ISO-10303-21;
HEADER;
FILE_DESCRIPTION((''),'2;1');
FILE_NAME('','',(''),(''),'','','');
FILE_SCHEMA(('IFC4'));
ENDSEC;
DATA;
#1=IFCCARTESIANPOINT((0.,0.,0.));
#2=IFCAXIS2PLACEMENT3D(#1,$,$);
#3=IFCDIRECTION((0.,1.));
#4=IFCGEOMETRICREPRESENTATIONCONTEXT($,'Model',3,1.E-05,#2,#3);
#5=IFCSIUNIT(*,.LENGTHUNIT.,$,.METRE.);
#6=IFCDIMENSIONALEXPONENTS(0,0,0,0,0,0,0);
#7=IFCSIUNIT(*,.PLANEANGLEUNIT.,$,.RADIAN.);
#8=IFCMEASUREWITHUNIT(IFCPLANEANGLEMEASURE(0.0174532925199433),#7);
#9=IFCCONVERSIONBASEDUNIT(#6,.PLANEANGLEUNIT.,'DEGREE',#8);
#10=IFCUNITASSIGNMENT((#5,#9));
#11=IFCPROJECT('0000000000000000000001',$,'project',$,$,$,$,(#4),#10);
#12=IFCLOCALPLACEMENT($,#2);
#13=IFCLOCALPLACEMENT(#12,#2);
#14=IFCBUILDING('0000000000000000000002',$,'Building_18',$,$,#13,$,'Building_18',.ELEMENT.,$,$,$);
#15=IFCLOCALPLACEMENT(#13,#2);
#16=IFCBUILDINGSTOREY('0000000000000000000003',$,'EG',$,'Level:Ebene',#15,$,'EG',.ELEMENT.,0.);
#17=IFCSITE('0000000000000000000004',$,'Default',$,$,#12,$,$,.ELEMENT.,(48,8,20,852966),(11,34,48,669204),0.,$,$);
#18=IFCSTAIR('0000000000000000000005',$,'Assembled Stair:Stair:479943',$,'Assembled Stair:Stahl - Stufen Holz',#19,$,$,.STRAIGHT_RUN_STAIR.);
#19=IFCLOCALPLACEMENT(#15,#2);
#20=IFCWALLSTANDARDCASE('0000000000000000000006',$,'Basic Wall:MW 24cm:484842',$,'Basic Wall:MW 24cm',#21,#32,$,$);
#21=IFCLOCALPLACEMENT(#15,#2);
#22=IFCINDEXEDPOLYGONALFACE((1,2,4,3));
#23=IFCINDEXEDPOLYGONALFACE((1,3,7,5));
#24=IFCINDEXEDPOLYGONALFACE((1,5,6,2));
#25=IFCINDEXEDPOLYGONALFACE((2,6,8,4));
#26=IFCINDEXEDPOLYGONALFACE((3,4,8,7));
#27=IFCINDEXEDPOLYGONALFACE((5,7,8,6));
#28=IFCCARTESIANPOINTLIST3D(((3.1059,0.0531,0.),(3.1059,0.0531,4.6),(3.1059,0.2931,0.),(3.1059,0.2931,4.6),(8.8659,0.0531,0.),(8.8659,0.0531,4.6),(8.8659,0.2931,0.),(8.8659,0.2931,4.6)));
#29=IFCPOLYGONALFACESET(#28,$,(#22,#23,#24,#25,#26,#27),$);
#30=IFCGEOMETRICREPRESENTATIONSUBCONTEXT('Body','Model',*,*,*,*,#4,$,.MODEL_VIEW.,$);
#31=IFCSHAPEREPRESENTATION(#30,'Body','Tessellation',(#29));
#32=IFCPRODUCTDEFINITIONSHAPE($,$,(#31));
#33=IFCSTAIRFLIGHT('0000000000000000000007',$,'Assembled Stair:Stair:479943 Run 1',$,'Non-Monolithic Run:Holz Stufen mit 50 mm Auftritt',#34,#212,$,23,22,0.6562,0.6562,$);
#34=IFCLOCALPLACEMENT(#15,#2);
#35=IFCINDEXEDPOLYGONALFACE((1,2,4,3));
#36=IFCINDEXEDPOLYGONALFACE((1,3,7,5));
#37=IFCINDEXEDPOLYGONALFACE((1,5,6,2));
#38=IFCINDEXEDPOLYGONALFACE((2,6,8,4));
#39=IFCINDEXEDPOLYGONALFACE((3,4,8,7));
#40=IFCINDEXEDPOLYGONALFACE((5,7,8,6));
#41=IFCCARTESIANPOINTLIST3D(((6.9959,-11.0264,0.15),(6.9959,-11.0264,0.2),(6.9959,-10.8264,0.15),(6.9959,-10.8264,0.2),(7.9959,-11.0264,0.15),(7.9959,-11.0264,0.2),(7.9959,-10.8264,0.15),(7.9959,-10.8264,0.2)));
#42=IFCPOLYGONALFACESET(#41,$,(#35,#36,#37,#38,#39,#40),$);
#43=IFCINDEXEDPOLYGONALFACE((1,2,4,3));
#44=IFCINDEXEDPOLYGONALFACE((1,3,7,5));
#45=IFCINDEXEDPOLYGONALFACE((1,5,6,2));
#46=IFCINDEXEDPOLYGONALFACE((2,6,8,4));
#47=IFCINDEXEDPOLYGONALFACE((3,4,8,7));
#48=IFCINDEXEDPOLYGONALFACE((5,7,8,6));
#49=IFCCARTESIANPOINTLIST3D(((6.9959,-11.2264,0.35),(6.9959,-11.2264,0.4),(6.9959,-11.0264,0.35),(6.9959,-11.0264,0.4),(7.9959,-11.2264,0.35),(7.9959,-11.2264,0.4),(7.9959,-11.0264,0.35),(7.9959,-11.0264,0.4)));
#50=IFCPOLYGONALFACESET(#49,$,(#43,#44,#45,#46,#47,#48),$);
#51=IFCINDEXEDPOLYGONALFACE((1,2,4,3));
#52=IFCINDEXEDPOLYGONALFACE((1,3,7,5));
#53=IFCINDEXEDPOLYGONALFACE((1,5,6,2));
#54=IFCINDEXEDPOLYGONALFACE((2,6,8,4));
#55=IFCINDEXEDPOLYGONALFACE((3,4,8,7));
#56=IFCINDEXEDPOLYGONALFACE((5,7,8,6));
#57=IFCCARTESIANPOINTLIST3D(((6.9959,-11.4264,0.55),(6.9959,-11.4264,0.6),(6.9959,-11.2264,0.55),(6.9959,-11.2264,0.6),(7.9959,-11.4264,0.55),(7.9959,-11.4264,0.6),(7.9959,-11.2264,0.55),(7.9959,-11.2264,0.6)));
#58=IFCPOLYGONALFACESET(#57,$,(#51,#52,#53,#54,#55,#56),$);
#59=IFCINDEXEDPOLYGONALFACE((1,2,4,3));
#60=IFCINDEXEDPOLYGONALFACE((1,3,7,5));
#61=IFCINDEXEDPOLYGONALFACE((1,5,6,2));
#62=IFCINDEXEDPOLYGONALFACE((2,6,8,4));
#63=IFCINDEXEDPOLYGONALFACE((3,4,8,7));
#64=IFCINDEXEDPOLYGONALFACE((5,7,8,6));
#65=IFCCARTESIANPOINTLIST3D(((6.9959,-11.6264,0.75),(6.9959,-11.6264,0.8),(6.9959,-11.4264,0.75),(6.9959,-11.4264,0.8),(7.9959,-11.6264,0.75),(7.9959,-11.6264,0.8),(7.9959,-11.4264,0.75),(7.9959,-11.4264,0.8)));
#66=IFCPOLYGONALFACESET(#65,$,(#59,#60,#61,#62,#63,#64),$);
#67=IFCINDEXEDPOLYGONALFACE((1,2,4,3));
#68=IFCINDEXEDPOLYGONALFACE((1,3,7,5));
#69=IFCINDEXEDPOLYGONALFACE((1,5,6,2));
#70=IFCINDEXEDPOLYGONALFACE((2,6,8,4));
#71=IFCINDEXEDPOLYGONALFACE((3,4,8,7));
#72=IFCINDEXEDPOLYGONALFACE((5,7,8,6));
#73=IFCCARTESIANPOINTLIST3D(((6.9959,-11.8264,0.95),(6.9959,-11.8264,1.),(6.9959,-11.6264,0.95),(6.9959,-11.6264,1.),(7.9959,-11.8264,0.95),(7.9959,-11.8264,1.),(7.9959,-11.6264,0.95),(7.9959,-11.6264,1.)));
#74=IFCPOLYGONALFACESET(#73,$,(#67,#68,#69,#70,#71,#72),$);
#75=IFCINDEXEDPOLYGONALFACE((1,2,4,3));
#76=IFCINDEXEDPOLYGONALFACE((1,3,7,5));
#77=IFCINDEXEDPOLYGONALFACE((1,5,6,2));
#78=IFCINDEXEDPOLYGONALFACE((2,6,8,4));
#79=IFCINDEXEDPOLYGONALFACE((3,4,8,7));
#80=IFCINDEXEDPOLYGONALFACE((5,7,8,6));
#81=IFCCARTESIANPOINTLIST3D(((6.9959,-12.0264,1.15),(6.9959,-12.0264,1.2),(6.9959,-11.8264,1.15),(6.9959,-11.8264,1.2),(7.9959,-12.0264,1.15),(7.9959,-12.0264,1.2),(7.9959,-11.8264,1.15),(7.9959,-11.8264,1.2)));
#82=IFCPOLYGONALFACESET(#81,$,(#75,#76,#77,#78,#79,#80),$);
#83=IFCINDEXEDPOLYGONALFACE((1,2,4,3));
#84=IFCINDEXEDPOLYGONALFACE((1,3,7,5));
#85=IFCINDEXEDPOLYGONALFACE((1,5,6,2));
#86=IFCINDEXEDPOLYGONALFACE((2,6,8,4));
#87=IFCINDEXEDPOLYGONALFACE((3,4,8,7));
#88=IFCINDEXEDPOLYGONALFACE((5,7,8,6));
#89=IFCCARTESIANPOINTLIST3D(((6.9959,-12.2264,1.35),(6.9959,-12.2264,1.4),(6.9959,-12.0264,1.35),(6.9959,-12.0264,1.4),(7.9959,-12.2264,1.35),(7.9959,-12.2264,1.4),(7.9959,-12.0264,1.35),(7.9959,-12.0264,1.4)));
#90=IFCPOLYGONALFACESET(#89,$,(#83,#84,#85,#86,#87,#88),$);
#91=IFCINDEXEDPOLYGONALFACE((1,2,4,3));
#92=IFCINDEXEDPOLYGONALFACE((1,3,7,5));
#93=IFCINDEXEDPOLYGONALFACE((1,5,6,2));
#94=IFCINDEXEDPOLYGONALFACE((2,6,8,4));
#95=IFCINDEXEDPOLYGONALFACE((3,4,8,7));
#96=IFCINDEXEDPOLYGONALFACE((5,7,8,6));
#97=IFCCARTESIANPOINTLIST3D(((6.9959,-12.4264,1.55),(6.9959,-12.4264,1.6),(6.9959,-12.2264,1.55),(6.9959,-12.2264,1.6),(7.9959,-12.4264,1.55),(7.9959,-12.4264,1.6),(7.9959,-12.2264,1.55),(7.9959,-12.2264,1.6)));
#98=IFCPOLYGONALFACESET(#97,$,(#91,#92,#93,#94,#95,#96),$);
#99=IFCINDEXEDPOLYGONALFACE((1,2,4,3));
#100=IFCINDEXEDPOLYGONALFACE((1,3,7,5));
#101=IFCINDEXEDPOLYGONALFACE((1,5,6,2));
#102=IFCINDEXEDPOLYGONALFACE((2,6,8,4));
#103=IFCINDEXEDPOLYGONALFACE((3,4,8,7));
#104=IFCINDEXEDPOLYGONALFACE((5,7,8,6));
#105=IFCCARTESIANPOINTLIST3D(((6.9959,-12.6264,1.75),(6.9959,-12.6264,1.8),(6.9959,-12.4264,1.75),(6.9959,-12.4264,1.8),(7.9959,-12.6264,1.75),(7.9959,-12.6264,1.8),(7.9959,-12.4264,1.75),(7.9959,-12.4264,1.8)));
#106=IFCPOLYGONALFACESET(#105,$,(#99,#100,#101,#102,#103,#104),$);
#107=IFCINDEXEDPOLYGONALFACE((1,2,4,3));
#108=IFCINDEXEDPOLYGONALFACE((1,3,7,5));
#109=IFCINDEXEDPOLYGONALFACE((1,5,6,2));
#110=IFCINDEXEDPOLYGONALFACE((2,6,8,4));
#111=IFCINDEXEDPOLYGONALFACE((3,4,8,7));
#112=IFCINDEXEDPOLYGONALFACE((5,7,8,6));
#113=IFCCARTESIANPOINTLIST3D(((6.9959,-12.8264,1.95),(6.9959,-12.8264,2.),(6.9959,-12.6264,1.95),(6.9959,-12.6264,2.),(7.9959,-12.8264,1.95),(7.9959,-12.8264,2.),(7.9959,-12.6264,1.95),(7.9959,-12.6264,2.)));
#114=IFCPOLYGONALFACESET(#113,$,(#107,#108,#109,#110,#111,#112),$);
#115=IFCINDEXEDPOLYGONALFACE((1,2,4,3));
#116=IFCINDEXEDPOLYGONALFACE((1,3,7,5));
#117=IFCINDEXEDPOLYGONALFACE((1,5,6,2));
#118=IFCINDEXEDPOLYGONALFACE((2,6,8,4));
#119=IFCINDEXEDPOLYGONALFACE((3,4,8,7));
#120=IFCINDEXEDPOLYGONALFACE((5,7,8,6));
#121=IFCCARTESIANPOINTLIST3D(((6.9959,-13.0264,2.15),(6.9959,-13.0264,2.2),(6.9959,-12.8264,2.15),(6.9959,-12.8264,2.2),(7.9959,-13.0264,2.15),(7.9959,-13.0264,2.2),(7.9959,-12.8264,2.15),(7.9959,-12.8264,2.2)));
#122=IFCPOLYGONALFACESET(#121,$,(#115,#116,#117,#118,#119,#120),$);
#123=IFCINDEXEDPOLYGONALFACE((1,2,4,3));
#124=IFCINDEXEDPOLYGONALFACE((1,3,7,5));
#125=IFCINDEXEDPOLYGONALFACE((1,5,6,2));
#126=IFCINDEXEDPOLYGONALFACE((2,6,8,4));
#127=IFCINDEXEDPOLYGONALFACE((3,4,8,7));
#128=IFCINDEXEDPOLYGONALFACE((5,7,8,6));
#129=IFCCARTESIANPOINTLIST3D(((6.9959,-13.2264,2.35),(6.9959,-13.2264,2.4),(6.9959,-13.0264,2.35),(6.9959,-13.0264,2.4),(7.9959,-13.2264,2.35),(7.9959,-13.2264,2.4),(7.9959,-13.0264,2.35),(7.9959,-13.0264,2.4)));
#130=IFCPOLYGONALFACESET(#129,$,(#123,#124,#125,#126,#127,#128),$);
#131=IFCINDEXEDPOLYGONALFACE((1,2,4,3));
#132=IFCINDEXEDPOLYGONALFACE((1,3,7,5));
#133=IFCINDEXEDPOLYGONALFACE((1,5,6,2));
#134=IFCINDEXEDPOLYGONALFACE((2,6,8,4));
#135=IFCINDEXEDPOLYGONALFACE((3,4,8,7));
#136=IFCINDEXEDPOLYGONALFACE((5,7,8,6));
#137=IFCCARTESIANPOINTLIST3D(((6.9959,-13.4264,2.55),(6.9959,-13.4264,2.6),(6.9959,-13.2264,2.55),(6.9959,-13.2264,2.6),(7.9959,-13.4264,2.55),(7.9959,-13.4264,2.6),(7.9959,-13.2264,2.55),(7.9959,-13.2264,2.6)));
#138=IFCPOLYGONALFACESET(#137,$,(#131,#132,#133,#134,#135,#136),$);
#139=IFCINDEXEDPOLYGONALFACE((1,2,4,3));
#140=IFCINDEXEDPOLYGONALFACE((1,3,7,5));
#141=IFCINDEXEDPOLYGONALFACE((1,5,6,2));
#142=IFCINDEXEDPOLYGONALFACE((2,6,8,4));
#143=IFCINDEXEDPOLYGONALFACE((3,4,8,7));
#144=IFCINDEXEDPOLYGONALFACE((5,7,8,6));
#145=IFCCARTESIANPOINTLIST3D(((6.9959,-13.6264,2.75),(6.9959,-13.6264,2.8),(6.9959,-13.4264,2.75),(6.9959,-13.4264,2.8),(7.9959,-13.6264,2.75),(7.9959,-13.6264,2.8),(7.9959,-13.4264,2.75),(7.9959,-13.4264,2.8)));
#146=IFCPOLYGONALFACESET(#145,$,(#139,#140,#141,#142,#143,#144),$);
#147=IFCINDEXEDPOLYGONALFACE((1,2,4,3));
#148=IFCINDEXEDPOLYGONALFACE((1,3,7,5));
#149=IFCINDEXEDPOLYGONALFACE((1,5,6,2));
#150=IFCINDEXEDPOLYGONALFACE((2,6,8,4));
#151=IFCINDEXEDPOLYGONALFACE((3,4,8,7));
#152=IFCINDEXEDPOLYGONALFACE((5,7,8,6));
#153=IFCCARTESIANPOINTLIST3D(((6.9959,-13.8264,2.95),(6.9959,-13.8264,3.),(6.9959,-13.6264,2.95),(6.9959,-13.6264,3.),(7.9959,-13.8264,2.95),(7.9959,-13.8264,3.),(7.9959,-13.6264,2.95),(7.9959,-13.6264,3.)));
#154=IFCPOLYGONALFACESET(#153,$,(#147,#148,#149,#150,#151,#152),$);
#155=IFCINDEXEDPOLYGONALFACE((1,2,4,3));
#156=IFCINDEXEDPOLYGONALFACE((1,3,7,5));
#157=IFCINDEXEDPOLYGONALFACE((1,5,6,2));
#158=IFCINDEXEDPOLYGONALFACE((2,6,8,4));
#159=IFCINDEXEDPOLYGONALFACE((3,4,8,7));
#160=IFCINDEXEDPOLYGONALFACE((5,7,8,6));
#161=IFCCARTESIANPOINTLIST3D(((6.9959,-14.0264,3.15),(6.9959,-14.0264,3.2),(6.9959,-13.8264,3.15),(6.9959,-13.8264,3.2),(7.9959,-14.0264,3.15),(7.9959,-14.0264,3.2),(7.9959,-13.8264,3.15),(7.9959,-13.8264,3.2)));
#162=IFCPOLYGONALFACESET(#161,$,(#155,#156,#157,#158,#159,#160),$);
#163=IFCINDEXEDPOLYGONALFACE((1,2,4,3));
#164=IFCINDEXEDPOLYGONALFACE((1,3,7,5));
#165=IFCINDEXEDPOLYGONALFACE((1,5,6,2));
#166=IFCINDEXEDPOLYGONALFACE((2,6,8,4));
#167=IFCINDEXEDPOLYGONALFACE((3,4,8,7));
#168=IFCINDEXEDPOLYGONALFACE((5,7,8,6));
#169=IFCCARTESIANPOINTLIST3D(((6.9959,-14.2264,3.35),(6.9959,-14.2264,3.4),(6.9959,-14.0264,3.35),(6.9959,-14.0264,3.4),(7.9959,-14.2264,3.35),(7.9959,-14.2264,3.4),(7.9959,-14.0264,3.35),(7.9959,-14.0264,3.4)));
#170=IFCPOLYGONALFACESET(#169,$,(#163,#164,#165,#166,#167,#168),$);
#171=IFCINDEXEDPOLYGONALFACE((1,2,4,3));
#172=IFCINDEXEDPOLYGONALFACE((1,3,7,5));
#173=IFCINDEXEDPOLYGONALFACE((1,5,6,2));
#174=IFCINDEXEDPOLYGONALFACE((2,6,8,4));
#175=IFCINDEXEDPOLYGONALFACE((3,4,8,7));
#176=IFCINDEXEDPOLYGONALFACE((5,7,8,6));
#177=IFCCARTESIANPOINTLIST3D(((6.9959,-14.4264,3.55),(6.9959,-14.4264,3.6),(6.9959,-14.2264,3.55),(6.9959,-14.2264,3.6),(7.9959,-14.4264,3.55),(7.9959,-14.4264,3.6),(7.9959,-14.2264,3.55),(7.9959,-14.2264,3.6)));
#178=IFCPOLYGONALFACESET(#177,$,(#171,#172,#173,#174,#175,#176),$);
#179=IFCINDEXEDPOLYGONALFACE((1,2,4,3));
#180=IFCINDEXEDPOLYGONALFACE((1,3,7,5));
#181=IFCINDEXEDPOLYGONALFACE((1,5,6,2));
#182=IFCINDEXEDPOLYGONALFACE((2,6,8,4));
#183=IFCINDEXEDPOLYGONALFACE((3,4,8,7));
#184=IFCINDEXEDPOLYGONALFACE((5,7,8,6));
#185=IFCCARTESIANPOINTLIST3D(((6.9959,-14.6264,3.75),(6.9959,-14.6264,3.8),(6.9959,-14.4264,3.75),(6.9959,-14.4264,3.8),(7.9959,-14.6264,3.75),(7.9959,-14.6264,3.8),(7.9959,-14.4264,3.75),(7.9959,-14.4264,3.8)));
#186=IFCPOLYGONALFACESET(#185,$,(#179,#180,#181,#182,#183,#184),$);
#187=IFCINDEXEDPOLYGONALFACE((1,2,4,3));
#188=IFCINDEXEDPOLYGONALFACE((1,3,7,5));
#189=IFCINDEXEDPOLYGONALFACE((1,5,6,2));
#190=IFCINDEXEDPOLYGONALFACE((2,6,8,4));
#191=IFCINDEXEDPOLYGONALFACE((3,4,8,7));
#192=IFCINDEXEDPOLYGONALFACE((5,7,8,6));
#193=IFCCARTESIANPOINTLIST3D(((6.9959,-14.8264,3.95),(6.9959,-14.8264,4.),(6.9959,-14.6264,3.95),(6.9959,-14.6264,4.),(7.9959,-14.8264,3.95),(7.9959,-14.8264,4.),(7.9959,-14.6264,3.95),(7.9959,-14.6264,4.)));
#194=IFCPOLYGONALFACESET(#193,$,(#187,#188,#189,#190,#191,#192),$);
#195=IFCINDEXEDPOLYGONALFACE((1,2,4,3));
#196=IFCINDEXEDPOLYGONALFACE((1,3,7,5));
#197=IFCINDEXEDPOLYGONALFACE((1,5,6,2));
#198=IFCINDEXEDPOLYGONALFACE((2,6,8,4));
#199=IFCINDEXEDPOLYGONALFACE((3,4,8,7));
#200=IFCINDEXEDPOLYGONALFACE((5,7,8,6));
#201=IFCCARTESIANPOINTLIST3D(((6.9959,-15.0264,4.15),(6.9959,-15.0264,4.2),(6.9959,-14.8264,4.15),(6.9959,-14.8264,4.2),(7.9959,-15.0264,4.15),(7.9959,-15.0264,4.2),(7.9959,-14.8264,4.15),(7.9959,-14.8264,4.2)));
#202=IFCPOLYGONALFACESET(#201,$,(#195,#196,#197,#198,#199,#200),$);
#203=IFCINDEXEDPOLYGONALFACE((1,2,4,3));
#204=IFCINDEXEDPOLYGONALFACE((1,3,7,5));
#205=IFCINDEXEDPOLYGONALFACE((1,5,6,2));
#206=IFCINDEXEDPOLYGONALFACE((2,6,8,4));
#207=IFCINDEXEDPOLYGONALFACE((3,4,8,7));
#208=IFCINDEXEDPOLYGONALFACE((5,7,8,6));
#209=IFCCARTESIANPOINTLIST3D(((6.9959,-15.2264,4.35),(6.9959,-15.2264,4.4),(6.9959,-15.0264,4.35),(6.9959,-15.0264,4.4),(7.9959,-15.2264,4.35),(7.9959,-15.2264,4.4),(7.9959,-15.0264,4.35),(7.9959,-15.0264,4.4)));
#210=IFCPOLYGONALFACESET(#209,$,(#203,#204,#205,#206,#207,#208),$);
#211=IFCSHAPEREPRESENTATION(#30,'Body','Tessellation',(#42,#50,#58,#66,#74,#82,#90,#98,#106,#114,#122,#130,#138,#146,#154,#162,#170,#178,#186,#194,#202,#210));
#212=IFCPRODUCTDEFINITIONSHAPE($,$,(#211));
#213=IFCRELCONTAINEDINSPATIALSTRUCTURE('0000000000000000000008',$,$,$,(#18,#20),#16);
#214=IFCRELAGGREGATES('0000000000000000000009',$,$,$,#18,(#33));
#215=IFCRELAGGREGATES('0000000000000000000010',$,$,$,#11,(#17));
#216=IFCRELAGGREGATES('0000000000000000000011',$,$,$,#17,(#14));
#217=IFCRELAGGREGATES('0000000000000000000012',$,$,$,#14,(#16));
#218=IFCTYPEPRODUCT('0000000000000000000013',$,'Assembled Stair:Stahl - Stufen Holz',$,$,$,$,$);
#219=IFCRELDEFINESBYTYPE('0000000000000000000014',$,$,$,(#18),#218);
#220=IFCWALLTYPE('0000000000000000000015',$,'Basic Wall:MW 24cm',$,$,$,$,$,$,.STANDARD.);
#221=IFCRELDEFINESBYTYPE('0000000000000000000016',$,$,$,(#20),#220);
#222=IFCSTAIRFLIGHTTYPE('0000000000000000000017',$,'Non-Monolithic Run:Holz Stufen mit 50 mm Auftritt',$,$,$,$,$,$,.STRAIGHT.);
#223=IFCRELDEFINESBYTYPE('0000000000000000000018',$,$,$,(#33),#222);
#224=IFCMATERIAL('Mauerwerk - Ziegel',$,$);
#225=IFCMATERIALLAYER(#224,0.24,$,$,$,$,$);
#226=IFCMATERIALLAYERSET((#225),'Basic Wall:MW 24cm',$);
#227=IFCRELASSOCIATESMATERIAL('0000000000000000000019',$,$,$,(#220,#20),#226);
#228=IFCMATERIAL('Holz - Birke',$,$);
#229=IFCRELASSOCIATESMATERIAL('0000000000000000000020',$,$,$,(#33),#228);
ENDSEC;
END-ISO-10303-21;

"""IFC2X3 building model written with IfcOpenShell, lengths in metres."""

from ifc_helpers import new_model, entity, si_unit, converted_unit, direction, frame, frame_2d, origin, place, context, subcontext, project, spatial, rectangle, extrude, material, layer, layer_set, layer_usage, type_object, element, aggregate, save


model = new_model("IFC2X3")

# Units and contexts
model_context = context("Model", 3, precision=1e-05, world=origin(), true_north=direction((0.0, 1.0)))
body_context = subcontext(model_context, "Body", "Model", "MODEL_VIEW")
ifc_project = project(units=[si_unit("LENGTHUNIT", "METRE"), converted_unit("PLANEANGLEUNIT", "DEGREE", entity("IfcPlaneAngleMeasure", 0.0174532925199433), si_unit("PLANEANGLEUNIT", "RADIAN"), dimensions=[0, 0, 0, 0, 0, 0, 0])], contexts=[model_context])

# Site, building, storey
site_placement = place(None, origin())
site = spatial("IfcSite", under=ifc_project, at=site_placement, Name="Default", CompositionType="ELEMENT", RefLatitude=(48, 8, 20, 852966), RefLongitude=(11, 34, 48, 669204), RefElevation=0.0)
building_placement = place(site_placement, origin())
building = spatial("IfcBuilding", under=site, at=building_placement, Name="Building_18", LongName="Building_18", CompositionType="ELEMENT")
storey_placement = place(building_placement, origin())
storey = spatial("IfcBuildingStorey", under=building, at=storey_placement, Name="EG", ObjectType="Level:Ebene", LongName="EG", CompositionType="ELEMENT", Elevation=0.0)

# Stair
type_product = type_object("IfcTypeProduct", Name="Assembled Stair:Stahl - Stufen Holz")
stair_1_placement = place(storey_placement, origin())
stair_1 = element("IfcStair", 1, at=stair_1_placement, inside=storey, type_object=type_product, Name="Assembled Stair:Stair:479943", ObjectType="Assembled Stair:Stahl - Stufen Holz", ShapeType="STRAIGHT_RUN_STAIR")

# Shared definitions
ifc_material_1 = material(Name="Mauerwerk - Ziegel")
ifc_layer = layer(ifc_material_1, 0.24)
ifc_layer_set = layer_set([ifc_layer], Name="Basic Wall:MW 24cm")
wall_type = type_object("IfcWallType", Name="Basic Wall:MW 24cm", PredefinedType="STANDARD", material=ifc_layer_set)

# Wall
ifc_layer_usage_1 = layer_usage(ifc_layer_set, "AXIS2", "NEGATIVE", 0.12)
wall_1_placement = place(storey_placement, frame((3.1059, 0.1731, 0.0)))
element("IfcWallStandardCase", 2, at=wall_1_placement, inside=storey, type_object=wall_type, material=ifc_layer_usage_1, Name="Basic Wall:MW 24cm:484842", ObjectType="Basic Wall:MW 24cm", context=body_context, shape_type="SweptSolid", body=[
    extrude(rectangle(XDim=5.76, YDim=0.24, at=frame_2d((2.88, 0.0), x_axis=(-1.0, 0.0))), origin(), (0.0, 0.0, 1.0), 4.6),
])

# Stair flight
ifc_material_2 = material(Name="Holz - Birke")
stair_flight_type = type_object("IfcStairFlightType", Name="Non-Monolithic Run:Holz Stufen mit 50 mm Auftritt", PredefinedType="STRAIGHT")
stair_flight_1_placement = place(stair_1_placement, origin())
stair_flight_1 = element("IfcStairFlight", 3, at=stair_flight_1_placement, type_object=stair_flight_type, material=ifc_material_2, Name="Assembled Stair:Stair:479943 Run 1", ObjectType="Non-Monolithic Run:Holz Stufen mit 50 mm Auftritt", NumberOfRiser=23, NumberOfTreads=22, RiserHeight=0.6562, TreadLength=0.6562, context=body_context, shape_type="SweptSolid", body=[
    extrude(rectangle(XDim=0.2, YDim=1.0, at=frame_2d((0.0, 0.0), x_axis=(1.0, 0.0))), frame((7.4959, -10.9264, 0.15), z_axis=(0.0, 0.0, 1.0), x_axis=(0.0, 1.0, 0.0)), (0.0, 0.0, 1.0), 0.05),
    extrude(rectangle(XDim=0.2, YDim=1.0, at=frame_2d((0.0, 0.0), x_axis=(1.0, 0.0))), frame((7.4959, -11.1264, 0.35), z_axis=(0.0, 0.0, 1.0), x_axis=(0.0, 1.0, 0.0)), (0.0, 0.0, 1.0), 0.05),
    extrude(rectangle(XDim=0.2, YDim=1.0, at=frame_2d((0.0, 0.0), x_axis=(1.0, 0.0))), frame((7.4959, -11.3264, 0.55), z_axis=(0.0, 0.0, 1.0), x_axis=(0.0, 1.0, 0.0)), (0.0, 0.0, 1.0), 0.05),
    extrude(rectangle(XDim=0.2, YDim=1.0, at=frame_2d((0.0, 0.0), x_axis=(1.0, 0.0))), frame((7.4959, -11.5264, 0.75), z_axis=(0.0, 0.0, 1.0), x_axis=(0.0, 1.0, 0.0)), (0.0, 0.0, 1.0), 0.05),
    extrude(rectangle(XDim=0.2, YDim=1.0, at=frame_2d((0.0, 0.0), x_axis=(1.0, 0.0))), frame((7.4959, -11.7264, 0.95), z_axis=(0.0, 0.0, 1.0), x_axis=(0.0, 1.0, 0.0)), (0.0, 0.0, 1.0), 0.05),
    extrude(rectangle(XDim=0.2, YDim=1.0, at=frame_2d((0.0, 0.0), x_axis=(1.0, 0.0))), frame((7.4959, -11.9264, 1.15), z_axis=(0.0, 0.0, 1.0), x_axis=(0.0, 1.0, 0.0)), (0.0, 0.0, 1.0), 0.05),
    extrude(rectangle(XDim=0.2, YDim=1.0, at=frame_2d((0.0, 0.0), x_axis=(1.0, 0.0))), frame((7.4959, -12.1264, 1.35), z_axis=(0.0, 0.0, 1.0), x_axis=(0.0, 1.0, 0.0)), (0.0, 0.0, 1.0), 0.05),
    extrude(rectangle(XDim=0.2, YDim=1.0, at=frame_2d((0.0, 0.0), x_axis=(1.0, 0.0))), frame((7.4959, -12.3264, 1.55), z_axis=(0.0, 0.0, 1.0), x_axis=(0.0, 1.0, 0.0)), (0.0, 0.0, 1.0), 0.05),
    extrude(rectangle(XDim=0.2, YDim=1.0, at=frame_2d((0.0, 0.0), x_axis=(1.0, 0.0))), frame((7.4959, -12.5264, 1.75), z_axis=(0.0, 0.0, 1.0), x_axis=(0.0, 1.0, 0.0)), (0.0, 0.0, 1.0), 0.05),
    extrude(rectangle(XDim=0.2, YDim=1.0, at=frame_2d((0.0, 0.0), x_axis=(1.0, 0.0))), frame((7.4959, -12.7264, 1.95), z_axis=(0.0, 0.0, 1.0), x_axis=(0.0, 1.0, 0.0)), (0.0, 0.0, 1.0), 0.05),
    extrude(rectangle(XDim=0.2, YDim=1.0, at=frame_2d((0.0, 0.0), x_axis=(1.0, 0.0))), frame((7.4959, -12.9264, 2.15), z_axis=(0.0, 0.0, 1.0), x_axis=(0.0, 1.0, 0.0)), (0.0, 0.0, 1.0), 0.05),
    extrude(rectangle(XDim=0.2, YDim=1.0, at=frame_2d((0.0, 0.0), x_axis=(1.0, 0.0))), frame((7.4959, -13.1264, 2.35), z_axis=(0.0, 0.0, 1.0), x_axis=(0.0, 1.0, 0.0)), (0.0, 0.0, 1.0), 0.05),
    extrude(rectangle(XDim=0.2, YDim=1.0, at=frame_2d((0.0, 0.0), x_axis=(1.0, 0.0))), frame((7.4959, -13.3264, 2.55), z_axis=(0.0, 0.0, 1.0), x_axis=(0.0, 1.0, 0.0)), (0.0, 0.0, 1.0), 0.05),
    extrude(rectangle(XDim=0.2, YDim=1.0, at=frame_2d((0.0, 0.0), x_axis=(1.0, 0.0))), frame((7.4959, -13.5264, 2.75), z_axis=(0.0, 0.0, 1.0), x_axis=(0.0, 1.0, 0.0)), (0.0, 0.0, 1.0), 0.05),
    extrude(rectangle(XDim=0.2, YDim=1.0, at=frame_2d((0.0, 0.0), x_axis=(1.0, 0.0))), frame((7.4959, -13.7264, 2.95), z_axis=(0.0, 0.0, 1.0), x_axis=(0.0, 1.0, 0.0)), (0.0, 0.0, 1.0), 0.05),
    extrude(rectangle(XDim=0.2, YDim=1.0, at=frame_2d((0.0, 0.0), x_axis=(1.0, 0.0))), frame((7.4959, -13.9264, 3.15), z_axis=(0.0, 0.0, 1.0), x_axis=(0.0, 1.0, 0.0)), (0.0, 0.0, 1.0), 0.05),
    extrude(rectangle(XDim=0.2, YDim=1.0, at=frame_2d((0.0, 0.0), x_axis=(1.0, 0.0))), frame((7.4959, -14.1264, 3.35), z_axis=(0.0, 0.0, 1.0), x_axis=(0.0, 1.0, 0.0)), (0.0, 0.0, 1.0), 0.05),
    extrude(rectangle(XDim=0.2, YDim=1.0, at=frame_2d((0.0, 0.0), x_axis=(1.0, 0.0))), frame((7.4959, -14.3264, 3.55), z_axis=(0.0, 0.0, 1.0), x_axis=(0.0, 1.0, 0.0)), (0.0, 0.0, 1.0), 0.05),
    extrude(rectangle(XDim=0.2, YDim=1.0, at=frame_2d((0.0, 0.0), x_axis=(1.0, 0.0))), frame((7.4959, -14.5264, 3.75), z_axis=(0.0, 0.0, 1.0), x_axis=(0.0, 1.0, 0.0)), (0.0, 0.0, 1.0), 0.05),
    extrude(rectangle(XDim=0.2, YDim=1.0, at=frame_2d((0.0, 0.0), x_axis=(1.0, 0.0))), frame((7.4959, -14.7264, 3.95), z_axis=(0.0, 0.0, 1.0), x_axis=(0.0, 1.0, 0.0)), (0.0, 0.0, 1.0), 0.05),
    extrude(rectangle(XDim=0.2, YDim=1.0, at=frame_2d((0.0, 0.0), x_axis=(1.0, 0.0))), frame((7.4959, -14.9264, 4.15), z_axis=(0.0, 0.0, 1.0), x_axis=(0.0, 1.0, 0.0)), (0.0, 0.0, 1.0), 0.05),
    extrude(rectangle(XDim=0.2, YDim=1.0, at=frame_2d((0.0, 0.0), x_axis=(1.0, 0.0))), frame((7.4959, -15.1264, 4.35), z_axis=(0.0, 0.0, 1.0), x_axis=(0.0, 1.0, 0.0)), (0.0, 0.0, 1.0), 0.05),
])
aggregate(stair_1, [stair_flight_1])

save(model, "model.ifc")
